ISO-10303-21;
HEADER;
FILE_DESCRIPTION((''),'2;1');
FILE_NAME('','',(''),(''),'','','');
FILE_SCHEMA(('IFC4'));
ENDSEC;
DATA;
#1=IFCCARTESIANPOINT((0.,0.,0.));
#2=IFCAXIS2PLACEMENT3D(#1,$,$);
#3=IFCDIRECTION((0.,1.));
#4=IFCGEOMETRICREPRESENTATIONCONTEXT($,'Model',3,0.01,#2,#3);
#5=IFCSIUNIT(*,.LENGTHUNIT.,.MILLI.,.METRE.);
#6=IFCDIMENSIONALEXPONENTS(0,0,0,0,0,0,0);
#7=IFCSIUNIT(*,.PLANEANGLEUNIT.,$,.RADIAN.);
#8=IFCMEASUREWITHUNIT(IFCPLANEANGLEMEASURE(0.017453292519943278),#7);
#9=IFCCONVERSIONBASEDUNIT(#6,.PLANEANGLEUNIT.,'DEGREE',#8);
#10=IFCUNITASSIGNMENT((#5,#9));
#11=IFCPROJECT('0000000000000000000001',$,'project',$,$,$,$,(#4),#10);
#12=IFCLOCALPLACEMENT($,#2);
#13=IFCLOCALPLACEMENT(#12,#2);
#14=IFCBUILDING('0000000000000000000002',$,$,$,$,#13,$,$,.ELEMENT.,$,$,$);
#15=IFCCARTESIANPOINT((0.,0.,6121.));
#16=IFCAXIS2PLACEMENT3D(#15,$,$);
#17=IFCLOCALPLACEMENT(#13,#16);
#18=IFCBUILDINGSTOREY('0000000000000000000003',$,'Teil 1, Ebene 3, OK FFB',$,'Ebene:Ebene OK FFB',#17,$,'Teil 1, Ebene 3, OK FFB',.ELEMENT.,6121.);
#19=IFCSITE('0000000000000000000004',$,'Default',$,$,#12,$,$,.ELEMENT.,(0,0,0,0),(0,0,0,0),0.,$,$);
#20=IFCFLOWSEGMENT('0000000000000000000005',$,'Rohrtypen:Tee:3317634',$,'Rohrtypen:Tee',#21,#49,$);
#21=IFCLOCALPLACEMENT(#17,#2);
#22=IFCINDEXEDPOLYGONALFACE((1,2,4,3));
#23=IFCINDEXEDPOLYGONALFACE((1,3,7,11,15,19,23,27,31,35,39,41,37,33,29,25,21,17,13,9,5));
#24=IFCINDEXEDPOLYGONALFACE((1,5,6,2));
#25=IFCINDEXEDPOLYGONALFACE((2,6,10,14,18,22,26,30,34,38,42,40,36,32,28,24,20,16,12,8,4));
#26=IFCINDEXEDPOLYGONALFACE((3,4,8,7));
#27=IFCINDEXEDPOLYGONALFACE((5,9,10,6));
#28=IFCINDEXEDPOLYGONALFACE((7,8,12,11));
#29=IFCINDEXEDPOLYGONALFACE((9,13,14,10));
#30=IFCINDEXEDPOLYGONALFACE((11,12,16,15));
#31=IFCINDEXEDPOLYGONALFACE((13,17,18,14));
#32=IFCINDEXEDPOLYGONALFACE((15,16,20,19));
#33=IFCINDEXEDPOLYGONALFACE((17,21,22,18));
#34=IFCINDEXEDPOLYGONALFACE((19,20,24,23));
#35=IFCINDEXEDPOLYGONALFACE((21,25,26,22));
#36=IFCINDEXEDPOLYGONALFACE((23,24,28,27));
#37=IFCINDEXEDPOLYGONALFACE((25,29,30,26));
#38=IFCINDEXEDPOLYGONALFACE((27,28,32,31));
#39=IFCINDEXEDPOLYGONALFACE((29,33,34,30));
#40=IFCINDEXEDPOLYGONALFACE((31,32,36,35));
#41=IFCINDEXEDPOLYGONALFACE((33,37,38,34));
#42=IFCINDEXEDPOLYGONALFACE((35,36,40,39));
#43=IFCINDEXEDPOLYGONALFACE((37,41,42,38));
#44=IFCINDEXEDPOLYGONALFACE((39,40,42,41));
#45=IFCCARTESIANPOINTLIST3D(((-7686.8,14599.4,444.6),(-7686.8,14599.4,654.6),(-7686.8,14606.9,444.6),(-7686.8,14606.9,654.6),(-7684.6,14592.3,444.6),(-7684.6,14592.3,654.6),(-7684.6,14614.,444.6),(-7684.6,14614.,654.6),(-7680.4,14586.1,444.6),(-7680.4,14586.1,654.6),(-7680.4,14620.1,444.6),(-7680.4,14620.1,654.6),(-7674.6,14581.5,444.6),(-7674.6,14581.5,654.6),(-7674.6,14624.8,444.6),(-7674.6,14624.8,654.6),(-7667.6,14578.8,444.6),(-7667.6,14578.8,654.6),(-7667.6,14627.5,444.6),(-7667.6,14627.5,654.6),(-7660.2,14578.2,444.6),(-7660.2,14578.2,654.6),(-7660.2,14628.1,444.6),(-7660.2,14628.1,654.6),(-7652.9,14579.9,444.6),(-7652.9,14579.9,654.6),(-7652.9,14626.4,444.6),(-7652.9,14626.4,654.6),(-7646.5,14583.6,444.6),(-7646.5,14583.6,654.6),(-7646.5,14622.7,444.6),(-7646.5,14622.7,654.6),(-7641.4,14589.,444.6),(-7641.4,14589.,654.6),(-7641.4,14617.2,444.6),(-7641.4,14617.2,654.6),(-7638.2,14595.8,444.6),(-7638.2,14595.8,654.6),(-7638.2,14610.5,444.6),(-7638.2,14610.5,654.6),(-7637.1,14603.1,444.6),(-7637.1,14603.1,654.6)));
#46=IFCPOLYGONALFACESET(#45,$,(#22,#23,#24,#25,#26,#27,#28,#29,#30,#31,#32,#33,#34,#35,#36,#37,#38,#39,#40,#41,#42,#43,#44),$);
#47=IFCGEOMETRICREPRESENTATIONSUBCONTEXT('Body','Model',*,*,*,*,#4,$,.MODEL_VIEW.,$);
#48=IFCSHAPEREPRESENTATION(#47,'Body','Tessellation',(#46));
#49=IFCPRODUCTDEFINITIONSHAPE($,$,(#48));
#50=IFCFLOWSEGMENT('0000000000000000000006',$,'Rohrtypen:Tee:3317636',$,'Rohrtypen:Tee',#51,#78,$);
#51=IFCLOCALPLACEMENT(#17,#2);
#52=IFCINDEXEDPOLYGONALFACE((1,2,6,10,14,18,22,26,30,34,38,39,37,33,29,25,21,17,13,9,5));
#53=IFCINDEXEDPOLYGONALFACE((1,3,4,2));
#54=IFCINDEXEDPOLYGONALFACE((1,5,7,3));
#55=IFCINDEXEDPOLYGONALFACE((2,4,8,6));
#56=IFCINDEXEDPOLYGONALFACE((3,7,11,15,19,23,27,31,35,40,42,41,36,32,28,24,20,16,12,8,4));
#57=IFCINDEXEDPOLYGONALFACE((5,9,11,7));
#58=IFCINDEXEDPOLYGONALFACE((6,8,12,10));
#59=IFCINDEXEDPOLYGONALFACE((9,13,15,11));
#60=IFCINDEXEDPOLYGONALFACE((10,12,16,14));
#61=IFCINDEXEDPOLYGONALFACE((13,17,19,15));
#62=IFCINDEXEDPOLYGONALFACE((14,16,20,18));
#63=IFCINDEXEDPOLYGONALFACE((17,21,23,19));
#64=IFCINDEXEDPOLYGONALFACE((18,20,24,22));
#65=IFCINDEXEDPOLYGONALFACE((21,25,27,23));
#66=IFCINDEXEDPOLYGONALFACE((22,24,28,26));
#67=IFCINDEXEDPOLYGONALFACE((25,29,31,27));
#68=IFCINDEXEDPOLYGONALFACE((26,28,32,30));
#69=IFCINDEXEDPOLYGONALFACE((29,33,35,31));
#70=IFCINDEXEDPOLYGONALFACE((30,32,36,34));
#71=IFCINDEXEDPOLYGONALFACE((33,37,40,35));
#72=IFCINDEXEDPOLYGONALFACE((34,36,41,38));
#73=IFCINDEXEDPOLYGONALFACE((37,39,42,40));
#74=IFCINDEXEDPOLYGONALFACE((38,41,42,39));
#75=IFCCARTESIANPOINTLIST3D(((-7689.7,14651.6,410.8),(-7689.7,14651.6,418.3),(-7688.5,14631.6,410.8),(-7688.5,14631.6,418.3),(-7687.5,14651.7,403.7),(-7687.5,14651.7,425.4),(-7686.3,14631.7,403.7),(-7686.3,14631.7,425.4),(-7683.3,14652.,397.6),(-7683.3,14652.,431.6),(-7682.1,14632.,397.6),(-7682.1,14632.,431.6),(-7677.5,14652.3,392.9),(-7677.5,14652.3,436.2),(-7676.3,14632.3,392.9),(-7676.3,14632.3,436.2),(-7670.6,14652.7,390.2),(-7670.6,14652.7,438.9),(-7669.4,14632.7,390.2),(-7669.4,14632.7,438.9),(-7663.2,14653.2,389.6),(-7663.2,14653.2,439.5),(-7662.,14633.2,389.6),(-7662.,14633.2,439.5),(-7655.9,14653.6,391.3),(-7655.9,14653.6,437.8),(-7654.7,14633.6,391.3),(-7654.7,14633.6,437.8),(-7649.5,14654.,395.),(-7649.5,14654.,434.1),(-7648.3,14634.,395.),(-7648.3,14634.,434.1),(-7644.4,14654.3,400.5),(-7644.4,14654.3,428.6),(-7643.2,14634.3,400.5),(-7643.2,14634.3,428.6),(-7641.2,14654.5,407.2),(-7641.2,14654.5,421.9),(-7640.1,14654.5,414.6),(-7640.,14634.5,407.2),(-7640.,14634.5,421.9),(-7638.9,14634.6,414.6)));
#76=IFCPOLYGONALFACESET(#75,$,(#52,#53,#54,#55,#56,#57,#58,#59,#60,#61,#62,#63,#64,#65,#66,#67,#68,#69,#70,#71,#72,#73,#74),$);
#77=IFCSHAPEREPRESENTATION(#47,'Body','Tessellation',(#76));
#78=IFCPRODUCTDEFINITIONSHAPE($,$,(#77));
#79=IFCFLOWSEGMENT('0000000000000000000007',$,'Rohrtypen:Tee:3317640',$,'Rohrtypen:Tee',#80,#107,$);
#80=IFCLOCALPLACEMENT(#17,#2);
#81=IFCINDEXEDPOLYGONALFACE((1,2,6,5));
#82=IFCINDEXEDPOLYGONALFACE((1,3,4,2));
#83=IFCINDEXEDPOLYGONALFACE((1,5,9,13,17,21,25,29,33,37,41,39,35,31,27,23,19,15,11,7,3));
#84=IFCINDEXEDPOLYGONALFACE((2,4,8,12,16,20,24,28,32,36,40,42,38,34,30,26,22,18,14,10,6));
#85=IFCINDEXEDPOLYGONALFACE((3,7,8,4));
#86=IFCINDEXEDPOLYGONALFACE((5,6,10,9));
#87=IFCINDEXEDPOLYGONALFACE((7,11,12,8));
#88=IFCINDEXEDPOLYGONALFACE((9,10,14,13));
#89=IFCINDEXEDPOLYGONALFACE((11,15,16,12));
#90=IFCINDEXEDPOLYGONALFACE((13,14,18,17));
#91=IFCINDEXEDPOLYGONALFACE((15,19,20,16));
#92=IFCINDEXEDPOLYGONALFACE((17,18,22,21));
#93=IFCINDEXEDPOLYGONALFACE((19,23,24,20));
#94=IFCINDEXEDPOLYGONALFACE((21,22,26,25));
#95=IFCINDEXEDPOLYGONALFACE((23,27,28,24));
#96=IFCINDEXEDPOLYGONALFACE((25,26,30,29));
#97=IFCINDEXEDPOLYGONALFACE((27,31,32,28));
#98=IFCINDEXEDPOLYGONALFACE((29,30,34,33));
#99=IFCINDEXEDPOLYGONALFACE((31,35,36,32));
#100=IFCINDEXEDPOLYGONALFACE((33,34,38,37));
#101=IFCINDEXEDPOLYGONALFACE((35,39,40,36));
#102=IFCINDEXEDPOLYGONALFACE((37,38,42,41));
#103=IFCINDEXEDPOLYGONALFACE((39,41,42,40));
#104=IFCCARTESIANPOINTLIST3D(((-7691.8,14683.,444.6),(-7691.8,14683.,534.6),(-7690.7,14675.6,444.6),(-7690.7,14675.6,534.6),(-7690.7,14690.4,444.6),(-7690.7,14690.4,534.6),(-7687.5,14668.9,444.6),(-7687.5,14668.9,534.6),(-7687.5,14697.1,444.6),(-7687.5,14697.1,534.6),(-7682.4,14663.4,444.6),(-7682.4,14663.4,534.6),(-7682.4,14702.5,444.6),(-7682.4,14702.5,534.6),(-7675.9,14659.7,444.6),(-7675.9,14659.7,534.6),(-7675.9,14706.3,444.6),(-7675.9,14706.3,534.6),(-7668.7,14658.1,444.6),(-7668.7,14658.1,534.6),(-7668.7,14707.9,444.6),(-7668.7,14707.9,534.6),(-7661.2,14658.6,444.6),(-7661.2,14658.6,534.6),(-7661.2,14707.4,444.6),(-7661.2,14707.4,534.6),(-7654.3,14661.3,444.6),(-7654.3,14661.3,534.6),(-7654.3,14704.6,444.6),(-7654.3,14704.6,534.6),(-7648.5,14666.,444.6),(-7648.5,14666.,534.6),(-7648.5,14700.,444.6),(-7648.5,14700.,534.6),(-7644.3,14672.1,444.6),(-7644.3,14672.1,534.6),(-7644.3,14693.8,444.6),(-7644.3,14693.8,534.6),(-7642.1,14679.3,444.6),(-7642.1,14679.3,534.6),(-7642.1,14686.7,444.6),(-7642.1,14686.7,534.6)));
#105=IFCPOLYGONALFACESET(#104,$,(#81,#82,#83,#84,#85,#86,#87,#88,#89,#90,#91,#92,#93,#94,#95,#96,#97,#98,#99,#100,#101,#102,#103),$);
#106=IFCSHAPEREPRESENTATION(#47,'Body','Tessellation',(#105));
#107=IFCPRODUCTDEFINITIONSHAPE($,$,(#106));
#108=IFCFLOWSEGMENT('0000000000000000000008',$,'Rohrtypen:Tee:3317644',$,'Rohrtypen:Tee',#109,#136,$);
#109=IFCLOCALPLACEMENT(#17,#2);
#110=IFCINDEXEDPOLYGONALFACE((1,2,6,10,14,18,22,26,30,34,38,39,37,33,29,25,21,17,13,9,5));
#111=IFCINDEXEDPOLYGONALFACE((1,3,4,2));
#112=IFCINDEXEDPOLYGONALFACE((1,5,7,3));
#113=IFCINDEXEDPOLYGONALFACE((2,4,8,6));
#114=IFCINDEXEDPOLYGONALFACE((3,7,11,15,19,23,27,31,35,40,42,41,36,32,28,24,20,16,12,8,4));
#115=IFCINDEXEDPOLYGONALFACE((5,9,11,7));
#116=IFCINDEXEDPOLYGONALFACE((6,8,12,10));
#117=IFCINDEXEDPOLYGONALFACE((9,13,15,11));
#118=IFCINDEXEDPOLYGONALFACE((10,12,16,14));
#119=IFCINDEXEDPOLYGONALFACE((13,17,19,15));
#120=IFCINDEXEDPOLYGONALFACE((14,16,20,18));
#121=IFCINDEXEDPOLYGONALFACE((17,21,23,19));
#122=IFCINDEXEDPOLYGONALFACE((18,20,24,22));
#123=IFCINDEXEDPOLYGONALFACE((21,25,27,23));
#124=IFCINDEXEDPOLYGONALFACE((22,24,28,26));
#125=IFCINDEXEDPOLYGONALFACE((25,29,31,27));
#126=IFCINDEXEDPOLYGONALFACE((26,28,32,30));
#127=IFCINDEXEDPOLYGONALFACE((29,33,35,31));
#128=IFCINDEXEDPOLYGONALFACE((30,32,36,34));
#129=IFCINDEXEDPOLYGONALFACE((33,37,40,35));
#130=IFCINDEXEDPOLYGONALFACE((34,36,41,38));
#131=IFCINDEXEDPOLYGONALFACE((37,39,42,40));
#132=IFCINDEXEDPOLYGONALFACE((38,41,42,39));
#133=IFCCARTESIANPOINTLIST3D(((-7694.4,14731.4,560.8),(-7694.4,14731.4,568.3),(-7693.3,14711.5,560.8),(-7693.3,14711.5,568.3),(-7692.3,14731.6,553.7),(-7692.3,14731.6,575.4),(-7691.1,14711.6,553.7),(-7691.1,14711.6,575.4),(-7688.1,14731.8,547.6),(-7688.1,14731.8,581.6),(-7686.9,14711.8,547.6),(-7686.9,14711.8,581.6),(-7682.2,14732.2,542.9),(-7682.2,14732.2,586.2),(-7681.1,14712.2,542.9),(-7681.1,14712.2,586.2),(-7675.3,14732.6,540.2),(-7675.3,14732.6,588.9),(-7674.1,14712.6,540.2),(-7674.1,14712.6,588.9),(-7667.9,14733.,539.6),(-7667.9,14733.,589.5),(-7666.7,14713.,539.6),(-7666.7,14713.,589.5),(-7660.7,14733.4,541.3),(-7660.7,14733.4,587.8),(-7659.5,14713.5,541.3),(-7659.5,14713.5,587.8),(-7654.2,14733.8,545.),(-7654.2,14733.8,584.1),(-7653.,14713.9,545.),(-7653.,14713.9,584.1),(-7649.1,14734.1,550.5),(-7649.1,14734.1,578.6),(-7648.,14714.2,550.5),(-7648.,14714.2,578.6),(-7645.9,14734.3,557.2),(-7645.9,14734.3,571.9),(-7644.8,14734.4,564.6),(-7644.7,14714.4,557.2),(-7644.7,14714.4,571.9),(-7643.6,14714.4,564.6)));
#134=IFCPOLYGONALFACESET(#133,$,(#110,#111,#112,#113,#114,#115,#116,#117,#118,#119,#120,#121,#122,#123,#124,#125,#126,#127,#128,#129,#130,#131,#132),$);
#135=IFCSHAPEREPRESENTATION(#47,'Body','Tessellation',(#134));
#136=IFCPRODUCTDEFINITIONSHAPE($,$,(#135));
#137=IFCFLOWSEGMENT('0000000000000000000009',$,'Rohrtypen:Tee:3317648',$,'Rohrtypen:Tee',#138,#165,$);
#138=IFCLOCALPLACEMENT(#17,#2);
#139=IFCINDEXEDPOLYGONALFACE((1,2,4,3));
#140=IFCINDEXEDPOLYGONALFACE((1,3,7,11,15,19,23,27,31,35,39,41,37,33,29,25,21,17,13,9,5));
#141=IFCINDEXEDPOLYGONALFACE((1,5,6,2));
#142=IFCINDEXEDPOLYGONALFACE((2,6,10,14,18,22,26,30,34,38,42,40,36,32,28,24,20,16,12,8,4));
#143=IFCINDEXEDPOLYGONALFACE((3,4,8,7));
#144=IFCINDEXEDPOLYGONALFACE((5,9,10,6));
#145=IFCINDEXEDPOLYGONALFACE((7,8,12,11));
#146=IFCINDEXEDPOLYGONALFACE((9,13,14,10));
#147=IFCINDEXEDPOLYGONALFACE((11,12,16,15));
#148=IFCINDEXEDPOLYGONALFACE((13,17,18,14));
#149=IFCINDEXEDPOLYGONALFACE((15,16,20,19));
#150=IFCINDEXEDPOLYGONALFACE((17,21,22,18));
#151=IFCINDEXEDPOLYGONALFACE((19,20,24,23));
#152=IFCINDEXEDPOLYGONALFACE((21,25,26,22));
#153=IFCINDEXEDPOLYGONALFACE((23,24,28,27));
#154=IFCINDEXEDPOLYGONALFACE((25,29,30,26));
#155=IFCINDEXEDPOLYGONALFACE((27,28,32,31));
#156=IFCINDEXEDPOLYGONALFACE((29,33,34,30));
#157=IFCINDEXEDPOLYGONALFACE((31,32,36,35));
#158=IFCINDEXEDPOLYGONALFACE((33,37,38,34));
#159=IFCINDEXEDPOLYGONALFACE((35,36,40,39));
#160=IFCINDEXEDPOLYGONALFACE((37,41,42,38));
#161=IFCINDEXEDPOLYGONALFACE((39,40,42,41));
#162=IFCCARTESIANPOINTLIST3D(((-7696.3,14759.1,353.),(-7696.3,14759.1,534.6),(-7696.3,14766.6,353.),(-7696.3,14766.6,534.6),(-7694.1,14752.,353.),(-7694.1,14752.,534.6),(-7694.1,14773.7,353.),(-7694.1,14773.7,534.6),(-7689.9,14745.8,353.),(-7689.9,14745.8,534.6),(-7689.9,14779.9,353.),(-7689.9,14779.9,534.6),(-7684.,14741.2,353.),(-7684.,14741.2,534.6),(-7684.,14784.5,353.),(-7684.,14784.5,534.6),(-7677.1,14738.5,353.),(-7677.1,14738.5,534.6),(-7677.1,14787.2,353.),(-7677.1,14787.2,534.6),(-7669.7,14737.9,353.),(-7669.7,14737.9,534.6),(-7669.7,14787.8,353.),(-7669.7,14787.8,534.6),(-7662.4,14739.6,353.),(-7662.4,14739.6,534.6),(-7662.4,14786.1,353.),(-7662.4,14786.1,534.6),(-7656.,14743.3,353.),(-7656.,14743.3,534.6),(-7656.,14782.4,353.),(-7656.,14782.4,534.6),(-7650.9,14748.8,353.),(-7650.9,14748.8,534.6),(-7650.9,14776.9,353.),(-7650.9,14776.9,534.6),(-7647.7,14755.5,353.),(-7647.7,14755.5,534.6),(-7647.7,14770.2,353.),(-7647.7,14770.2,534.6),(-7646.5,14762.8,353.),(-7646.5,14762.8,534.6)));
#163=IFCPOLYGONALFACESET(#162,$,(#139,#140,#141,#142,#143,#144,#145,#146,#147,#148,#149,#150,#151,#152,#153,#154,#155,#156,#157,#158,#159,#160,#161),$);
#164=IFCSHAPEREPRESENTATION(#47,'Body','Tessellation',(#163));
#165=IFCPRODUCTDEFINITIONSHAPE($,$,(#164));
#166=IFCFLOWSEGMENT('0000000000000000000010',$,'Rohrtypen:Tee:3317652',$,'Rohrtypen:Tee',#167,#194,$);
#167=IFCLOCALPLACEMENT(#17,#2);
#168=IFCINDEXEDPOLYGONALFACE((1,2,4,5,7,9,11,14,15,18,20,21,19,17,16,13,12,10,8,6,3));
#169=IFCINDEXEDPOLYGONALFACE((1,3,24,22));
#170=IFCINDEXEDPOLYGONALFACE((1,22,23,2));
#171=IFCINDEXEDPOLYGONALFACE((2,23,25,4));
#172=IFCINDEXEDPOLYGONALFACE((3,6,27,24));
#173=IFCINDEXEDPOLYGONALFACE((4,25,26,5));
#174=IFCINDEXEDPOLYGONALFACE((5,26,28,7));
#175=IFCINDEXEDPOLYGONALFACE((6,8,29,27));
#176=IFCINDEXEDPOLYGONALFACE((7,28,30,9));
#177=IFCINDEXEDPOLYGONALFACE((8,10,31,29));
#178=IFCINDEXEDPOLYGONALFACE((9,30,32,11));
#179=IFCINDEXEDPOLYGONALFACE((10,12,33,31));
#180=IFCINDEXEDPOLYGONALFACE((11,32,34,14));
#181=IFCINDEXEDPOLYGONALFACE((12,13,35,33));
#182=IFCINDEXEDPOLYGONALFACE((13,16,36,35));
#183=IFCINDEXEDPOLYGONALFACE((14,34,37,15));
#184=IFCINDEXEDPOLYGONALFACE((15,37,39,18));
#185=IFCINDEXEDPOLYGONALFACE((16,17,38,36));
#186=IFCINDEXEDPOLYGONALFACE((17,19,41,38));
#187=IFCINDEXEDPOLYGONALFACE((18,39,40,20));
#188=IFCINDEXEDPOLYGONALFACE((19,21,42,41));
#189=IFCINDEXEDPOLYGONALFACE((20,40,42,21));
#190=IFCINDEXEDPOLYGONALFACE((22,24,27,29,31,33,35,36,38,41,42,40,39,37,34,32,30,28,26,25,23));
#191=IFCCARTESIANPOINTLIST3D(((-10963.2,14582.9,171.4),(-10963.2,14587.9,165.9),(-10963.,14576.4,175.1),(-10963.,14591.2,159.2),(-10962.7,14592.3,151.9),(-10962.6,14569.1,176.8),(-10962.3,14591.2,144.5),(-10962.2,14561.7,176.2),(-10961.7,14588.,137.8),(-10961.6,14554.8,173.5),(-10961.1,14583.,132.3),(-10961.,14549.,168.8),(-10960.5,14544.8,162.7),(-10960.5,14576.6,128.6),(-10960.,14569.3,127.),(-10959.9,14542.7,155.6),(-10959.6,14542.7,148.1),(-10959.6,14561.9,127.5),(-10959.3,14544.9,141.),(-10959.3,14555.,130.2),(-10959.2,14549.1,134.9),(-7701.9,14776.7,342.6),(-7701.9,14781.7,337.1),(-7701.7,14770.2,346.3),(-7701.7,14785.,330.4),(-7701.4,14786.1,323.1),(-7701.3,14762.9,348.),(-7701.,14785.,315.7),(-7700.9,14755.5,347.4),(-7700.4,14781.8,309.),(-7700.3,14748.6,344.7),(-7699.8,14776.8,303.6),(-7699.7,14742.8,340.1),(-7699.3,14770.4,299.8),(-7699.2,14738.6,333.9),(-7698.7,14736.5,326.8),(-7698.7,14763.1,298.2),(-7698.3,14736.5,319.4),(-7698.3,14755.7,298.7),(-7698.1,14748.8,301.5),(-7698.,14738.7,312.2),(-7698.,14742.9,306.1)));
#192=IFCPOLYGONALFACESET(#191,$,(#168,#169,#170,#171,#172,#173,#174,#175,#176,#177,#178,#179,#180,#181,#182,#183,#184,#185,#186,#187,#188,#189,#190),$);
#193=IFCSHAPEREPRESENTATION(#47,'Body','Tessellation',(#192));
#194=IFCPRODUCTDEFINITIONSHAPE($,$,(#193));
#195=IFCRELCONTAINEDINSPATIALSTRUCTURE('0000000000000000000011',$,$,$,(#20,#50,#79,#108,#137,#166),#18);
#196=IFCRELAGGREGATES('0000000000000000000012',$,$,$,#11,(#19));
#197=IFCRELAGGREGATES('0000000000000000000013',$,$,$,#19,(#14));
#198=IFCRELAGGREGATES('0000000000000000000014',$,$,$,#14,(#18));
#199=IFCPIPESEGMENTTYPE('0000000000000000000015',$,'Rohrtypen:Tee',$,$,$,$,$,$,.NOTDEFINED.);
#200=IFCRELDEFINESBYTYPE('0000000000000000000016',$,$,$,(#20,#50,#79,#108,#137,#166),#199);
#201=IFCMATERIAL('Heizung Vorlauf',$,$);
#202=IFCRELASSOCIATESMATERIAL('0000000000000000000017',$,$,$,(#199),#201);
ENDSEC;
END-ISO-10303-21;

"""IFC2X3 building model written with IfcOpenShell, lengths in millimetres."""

from ifc_helpers import new_model, entity, si_unit, converted_unit, direction, frame, frame_2d, origin, origin_2d_with_axis, place, context, subcontext, project, spatial, circle, extrude, material, type_object, element, save


model = new_model("IFC2X3")

# Units and contexts
model_context = context("Model", 3, precision=0.01, world=origin(), true_north=direction((0.0, 1.0)))
body_context = subcontext(model_context, "Body", "Model", "MODEL_VIEW")
ifc_project = project(units=[si_unit("LENGTHUNIT", "METRE", prefix="MILLI"), converted_unit("PLANEANGLEUNIT", "DEGREE", entity("IfcPlaneAngleMeasure", 0.017453292519943278), si_unit("PLANEANGLEUNIT", "RADIAN"), dimensions=[0, 0, 0, 0, 0, 0, 0])], contexts=[model_context])

# Site, building, storey
site_placement = place(None, origin())
site = spatial("IfcSite", under=ifc_project, at=site_placement, Name="Default", CompositionType="ELEMENT", RefLatitude=(0, 0, 0, 0), RefLongitude=(0, 0, 0, 0), RefElevation=0.0)
building_placement = place(site_placement, origin())
building = spatial("IfcBuilding", under=site, at=building_placement, CompositionType="ELEMENT")
storey_placement = place(building_placement, frame((0.0, 0.0, 6121.0)))
storey = spatial("IfcBuildingStorey", under=building, at=storey_placement, Name="Teil 1, Ebene 3, OK FFB", ObjectType="Ebene:Ebene OK FFB", LongName="Teil 1, Ebene 3, OK FFB", CompositionType="ELEMENT", Elevation=6121.0)

# Flow segments
ifc_material = material(Name="Heizung Vorlauf")
pipe_segment_type = type_object("IfcPipeSegmentType", Name="Rohrtypen:Tee", PredefinedType="NOTDEFINED", material=ifc_material)
flow_segment_1_placement = place(storey_placement, origin())
element("IfcFlowSegment", 1, at=flow_segment_1_placement, inside=storey, type_object=pipe_segment_type, Name="Rohrtypen:Tee:3317634", ObjectType="Rohrtypen:Tee", context=body_context, shape_type="SweptSolid", body=[
    extrude(circle(Radius=25.0, at=frame_2d((0.0, 0.0), x_axis=(1.0, 0.0))), frame((-7662.1, 14603.1, 444.6)), (0.0, 0.0, 1.0), 210.0),
])
flow_segment_2_placement = place(storey_placement, origin())
element("IfcFlowSegment", 2, at=flow_segment_2_placement, inside=storey, type_object=pipe_segment_type, Name="Rohrtypen:Tee:3317636", ObjectType="Rohrtypen:Tee", context=body_context, shape_type="SweptSolid", body=[
    extrude(circle(Radius=25.0, at=origin_2d_with_axis()), frame((-7663.8, 14633.1, 414.6), z_axis=(-0.059319, 0.998239, 0.0), x_axis=(0.998239, 0.059319, 0.0)), (0.0, 0.0, 1.0), 20.0),
])
flow_segment_3_placement = place(storey_placement, origin())
element("IfcFlowSegment", 3, at=flow_segment_3_placement, inside=storey, type_object=pipe_segment_type, Name="Rohrtypen:Tee:3317640", ObjectType="Rohrtypen:Tee", context=body_context, shape_type="SweptSolid", body=[
    extrude(circle(Radius=25.0, at=frame_2d((0.0, 0.0), x_axis=(1.0, 0.0))), frame((-7666.8, 14683.0, 444.6), z_axis=(0.0, 0.0, 1.0), x_axis=(-1.0, 0.0, 0.0)), (0.0, 0.0, 1.0), 90.0),
])
flow_segment_4_placement = place(storey_placement, origin())
element("IfcFlowSegment", 4, at=flow_segment_4_placement, inside=storey, type_object=pipe_segment_type, Name="Rohrtypen:Tee:3317644", ObjectType="Rohrtypen:Tee", context=body_context, shape_type="SweptSolid", body=[
    extrude(circle(Radius=25.0, at=frame_2d((0.0, 0.0), x_axis=(1.0, 0.0))), frame((-7669.8, 14732.9, 564.6), z_axis=(0.059319, -0.998239, 0.0), x_axis=(0.998239, 0.059319, 0.0)), (0.0, 0.0, 1.0), 20.0),
])
flow_segment_5_placement = place(storey_placement, origin())
element("IfcFlowSegment", 5, at=flow_segment_5_placement, inside=storey, type_object=pipe_segment_type, Name="Rohrtypen:Tee:3317648", ObjectType="Rohrtypen:Tee", context=body_context, shape_type="SweptSolid", body=[
    extrude(circle(Radius=25.0, at=origin_2d_with_axis()), frame((-7671.5, 14762.8, 353.0)), (0.0, 0.0, 1.0), 181.5),
])
flow_segment_6_placement = place(storey_placement, origin())
element("IfcFlowSegment", 6, at=flow_segment_6_placement, inside=storey, type_object=pipe_segment_type, Name="Rohrtypen:Tee:3317652", ObjectType="Rohrtypen:Tee", context=body_context, shape_type="SweptSolid", body=[
    extrude(circle(Radius=25.0, at=frame_2d((0.0, 0.0), x_axis=(1.0, 0.0))), frame((-10961.2, 14567.4, 151.9), z_axis=(0.996871, 0.059238, 0.052336), x_axis=(-0.059319, 0.998239, 0.0)), (0.0, 0.0, 1.0), 3271.5),
])

save(model, "model.ifc")
